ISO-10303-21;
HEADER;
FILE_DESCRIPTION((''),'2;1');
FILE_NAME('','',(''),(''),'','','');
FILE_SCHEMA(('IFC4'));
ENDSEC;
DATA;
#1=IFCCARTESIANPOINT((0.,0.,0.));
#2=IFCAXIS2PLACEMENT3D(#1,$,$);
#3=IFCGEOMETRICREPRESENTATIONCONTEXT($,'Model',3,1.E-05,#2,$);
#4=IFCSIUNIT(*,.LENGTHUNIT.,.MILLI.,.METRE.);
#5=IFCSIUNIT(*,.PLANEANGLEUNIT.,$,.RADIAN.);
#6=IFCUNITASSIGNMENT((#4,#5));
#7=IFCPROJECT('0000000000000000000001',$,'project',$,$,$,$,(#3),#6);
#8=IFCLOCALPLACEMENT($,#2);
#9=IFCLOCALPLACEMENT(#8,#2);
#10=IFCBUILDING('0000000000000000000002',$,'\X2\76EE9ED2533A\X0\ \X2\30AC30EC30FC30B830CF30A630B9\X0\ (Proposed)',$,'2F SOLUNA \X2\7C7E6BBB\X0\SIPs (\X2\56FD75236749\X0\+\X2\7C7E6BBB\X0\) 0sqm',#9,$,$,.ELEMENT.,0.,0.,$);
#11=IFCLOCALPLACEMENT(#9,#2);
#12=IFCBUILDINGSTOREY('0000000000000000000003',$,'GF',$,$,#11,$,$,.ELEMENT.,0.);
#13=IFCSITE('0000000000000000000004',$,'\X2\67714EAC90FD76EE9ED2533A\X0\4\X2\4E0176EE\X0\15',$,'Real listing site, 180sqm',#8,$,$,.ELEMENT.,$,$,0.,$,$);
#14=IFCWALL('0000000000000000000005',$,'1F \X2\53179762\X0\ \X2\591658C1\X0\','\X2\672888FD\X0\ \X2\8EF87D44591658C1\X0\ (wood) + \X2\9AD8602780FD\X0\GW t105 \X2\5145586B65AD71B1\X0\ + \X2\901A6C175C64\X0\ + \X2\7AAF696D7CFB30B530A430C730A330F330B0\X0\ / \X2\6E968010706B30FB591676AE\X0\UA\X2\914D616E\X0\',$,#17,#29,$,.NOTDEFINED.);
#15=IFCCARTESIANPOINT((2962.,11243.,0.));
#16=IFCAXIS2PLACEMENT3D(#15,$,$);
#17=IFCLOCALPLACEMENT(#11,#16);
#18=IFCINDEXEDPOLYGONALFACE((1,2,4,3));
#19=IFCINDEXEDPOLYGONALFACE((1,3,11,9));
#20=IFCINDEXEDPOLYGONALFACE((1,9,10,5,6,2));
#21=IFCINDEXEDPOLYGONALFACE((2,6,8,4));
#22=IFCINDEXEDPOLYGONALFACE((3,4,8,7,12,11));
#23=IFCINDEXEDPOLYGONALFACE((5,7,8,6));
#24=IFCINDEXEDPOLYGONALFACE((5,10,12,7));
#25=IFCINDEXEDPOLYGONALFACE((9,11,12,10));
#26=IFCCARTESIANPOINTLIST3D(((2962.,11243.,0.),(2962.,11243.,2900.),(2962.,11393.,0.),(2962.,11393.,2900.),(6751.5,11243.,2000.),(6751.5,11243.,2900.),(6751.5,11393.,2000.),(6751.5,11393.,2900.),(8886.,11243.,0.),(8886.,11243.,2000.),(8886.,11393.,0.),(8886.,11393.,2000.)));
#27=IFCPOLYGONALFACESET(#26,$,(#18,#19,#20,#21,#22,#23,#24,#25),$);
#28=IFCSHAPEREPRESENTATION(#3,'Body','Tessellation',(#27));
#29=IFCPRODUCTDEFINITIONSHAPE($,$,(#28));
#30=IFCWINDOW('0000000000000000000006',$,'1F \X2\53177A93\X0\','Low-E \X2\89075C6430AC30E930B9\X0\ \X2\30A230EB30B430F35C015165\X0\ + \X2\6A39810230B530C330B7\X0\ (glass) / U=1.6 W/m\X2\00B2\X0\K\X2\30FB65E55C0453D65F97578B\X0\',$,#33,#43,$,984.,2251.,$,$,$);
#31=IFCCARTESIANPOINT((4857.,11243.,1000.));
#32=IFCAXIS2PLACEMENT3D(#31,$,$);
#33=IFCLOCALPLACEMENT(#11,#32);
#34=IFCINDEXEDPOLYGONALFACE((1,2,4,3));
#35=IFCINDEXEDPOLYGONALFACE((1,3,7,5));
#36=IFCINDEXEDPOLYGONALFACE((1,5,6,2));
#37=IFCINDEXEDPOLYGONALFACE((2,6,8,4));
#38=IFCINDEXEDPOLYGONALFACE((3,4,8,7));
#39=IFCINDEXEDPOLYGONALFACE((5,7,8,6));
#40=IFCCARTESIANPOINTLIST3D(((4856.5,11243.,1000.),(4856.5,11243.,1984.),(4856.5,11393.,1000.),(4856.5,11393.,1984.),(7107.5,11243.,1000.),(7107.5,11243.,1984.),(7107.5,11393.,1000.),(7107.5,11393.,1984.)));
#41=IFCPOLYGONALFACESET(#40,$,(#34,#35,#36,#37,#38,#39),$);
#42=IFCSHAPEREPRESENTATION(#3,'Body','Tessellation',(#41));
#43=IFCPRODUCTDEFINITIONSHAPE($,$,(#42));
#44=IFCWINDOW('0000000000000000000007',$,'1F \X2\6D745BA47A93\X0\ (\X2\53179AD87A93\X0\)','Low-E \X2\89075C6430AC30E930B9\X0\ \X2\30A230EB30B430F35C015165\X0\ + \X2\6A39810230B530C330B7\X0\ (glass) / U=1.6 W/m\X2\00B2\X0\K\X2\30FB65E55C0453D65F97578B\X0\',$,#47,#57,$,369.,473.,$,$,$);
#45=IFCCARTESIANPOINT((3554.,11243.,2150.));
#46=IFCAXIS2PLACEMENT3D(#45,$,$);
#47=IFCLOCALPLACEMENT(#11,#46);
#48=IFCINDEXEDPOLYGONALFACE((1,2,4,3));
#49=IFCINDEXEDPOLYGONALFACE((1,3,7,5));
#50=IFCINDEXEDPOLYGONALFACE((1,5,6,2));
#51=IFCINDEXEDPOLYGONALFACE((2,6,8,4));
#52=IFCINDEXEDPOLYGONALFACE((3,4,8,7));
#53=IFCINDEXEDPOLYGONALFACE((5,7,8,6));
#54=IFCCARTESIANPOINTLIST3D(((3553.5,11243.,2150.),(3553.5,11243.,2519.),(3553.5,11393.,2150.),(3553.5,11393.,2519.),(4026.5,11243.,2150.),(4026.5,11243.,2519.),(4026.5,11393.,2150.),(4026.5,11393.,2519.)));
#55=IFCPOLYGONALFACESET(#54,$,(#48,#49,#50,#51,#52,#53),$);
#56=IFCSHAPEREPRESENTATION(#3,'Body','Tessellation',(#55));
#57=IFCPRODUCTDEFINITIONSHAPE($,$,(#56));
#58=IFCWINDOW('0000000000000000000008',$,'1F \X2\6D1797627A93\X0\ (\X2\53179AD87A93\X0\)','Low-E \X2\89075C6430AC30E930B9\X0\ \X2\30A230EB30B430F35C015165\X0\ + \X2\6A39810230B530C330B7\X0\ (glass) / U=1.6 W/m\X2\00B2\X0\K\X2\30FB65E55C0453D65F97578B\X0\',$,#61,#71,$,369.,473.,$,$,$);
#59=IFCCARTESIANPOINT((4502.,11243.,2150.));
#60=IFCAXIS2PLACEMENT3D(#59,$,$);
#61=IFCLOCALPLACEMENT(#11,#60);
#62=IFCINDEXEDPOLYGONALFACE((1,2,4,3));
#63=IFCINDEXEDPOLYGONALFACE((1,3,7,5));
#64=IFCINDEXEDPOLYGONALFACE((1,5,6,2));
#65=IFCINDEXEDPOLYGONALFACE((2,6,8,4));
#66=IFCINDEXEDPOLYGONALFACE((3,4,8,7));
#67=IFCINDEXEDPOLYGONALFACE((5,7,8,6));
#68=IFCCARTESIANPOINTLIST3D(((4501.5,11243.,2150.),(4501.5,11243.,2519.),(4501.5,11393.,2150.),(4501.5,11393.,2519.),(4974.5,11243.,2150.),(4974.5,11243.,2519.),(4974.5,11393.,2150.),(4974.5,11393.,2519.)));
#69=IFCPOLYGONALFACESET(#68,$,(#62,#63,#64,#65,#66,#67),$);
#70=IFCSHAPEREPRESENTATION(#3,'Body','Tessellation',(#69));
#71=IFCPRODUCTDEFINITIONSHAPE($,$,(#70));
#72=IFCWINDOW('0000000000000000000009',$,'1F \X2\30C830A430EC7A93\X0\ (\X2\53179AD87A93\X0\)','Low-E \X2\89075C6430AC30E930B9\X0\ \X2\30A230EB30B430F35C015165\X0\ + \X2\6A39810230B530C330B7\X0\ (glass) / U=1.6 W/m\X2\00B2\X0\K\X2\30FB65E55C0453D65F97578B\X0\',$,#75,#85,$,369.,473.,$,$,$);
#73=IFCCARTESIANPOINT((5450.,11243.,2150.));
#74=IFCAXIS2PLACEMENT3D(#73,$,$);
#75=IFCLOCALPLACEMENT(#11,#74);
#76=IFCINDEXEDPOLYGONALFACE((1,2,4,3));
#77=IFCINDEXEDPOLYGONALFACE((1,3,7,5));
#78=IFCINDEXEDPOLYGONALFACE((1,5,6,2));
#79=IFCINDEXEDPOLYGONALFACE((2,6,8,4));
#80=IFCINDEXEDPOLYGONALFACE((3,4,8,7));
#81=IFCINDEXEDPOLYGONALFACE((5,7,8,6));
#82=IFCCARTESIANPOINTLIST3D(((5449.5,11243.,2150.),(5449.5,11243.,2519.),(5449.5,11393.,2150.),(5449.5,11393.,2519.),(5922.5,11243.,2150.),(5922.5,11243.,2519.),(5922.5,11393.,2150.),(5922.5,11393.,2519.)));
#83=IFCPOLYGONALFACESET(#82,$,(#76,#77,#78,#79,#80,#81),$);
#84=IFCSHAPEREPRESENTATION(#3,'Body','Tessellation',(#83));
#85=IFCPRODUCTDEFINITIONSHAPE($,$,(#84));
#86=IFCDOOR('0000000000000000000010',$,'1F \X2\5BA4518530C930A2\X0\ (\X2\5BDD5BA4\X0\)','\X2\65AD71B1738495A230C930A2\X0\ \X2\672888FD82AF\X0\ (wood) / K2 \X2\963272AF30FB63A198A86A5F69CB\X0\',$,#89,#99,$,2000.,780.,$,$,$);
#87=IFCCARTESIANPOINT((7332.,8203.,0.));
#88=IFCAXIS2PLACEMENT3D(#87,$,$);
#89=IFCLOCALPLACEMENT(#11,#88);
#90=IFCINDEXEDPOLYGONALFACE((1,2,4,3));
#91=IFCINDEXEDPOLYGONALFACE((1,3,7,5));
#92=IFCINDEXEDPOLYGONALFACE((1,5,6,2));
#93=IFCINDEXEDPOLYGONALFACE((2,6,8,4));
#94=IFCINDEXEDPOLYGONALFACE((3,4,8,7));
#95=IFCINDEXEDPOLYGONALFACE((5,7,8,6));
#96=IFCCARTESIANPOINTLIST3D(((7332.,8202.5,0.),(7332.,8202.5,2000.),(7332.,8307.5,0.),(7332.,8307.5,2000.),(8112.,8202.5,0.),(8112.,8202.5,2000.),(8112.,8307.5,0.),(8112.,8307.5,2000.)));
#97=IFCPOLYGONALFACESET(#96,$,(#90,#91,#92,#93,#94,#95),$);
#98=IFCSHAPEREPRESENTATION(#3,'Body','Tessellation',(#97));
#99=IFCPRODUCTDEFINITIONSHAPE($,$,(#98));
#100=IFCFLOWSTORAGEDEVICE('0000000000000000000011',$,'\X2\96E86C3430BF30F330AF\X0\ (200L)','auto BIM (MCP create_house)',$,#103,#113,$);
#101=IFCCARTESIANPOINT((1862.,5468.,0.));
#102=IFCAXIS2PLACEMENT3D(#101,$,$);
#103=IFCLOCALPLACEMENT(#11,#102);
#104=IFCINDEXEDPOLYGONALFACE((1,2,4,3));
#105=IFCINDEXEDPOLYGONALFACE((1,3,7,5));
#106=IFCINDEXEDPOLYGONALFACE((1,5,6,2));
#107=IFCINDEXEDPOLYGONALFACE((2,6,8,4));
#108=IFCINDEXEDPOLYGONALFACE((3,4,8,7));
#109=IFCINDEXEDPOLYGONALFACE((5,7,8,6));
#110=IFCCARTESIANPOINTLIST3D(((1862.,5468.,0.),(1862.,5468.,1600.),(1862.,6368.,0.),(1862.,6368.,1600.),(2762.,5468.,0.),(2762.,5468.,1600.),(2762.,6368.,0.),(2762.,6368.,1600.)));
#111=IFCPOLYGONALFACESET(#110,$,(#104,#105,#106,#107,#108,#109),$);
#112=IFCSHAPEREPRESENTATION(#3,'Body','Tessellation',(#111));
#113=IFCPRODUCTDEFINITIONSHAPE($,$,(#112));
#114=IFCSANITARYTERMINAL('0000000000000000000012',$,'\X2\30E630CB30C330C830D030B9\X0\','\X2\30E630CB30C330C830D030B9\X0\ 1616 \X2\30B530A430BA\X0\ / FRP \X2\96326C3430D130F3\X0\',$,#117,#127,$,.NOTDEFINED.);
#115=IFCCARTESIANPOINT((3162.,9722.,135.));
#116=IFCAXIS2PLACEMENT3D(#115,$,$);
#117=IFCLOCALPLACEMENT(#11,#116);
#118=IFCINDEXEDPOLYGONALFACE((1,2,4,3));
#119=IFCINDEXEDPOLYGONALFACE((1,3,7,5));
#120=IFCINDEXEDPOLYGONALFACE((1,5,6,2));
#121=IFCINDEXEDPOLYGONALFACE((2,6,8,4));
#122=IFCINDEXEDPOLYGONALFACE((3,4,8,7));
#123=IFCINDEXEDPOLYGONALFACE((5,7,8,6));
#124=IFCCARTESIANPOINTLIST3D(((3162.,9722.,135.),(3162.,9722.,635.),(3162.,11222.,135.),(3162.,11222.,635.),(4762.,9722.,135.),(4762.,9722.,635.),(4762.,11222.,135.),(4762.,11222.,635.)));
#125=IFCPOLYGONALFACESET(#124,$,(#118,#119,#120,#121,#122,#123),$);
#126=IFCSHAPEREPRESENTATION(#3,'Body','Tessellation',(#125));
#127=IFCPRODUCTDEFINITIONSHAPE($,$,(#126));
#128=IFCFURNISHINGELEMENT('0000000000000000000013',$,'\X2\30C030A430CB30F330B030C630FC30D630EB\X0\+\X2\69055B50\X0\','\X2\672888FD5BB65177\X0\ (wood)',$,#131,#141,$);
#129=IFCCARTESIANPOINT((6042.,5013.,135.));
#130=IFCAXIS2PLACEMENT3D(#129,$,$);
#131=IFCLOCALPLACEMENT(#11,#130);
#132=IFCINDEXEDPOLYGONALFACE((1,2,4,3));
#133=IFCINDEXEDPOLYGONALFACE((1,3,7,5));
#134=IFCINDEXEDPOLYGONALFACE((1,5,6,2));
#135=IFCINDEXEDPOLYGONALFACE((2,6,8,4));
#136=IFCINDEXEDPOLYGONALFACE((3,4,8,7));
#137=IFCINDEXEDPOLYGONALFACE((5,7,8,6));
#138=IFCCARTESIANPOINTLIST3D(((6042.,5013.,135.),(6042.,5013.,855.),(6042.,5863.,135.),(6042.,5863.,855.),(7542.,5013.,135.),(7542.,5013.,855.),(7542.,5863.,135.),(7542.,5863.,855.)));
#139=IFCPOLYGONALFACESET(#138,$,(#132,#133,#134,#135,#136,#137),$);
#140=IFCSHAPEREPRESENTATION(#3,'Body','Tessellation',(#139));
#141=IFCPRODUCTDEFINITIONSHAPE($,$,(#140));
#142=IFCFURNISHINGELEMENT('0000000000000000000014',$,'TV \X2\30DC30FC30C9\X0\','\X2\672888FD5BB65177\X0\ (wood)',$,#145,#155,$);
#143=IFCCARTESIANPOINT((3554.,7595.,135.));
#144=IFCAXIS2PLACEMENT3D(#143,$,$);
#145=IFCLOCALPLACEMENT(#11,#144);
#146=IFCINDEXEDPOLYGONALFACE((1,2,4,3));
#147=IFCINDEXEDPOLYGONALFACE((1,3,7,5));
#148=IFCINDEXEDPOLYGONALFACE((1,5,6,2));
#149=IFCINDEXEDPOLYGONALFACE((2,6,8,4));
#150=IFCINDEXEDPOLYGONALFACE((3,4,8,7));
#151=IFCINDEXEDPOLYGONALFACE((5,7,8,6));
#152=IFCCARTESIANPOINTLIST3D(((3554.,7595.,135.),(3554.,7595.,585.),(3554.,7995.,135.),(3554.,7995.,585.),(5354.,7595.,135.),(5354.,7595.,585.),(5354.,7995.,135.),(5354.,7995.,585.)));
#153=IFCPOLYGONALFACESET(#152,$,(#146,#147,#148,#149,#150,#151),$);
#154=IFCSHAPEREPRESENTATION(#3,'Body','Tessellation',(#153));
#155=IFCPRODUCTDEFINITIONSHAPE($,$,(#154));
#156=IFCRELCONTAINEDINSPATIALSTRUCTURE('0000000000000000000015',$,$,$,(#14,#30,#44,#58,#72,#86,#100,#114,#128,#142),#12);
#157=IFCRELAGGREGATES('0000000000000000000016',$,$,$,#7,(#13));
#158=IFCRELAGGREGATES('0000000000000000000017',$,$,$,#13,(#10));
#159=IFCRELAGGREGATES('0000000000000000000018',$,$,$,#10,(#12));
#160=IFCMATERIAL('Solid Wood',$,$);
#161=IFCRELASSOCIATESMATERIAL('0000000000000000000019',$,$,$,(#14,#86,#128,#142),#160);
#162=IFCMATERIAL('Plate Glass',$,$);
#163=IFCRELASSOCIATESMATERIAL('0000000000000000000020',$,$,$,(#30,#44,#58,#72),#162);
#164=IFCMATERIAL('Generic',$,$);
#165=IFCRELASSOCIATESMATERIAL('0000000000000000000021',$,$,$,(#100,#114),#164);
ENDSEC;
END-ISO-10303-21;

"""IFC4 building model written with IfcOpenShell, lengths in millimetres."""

from ifc_helpers import new_model, si_unit, frame, frame_2d, origin, place, context, project, spatial, rectangle, extrude, material, element, fill, save


model = new_model("IFC4")

# Units and contexts
model_context = context("Model", 3, precision=1e-05, world=origin())
ifc_project = project(units=[si_unit("LENGTHUNIT", "METRE", prefix="MILLI"), si_unit("PLANEANGLEUNIT", "RADIAN")], contexts=[model_context])

# Site, building, storey
site_placement = place(None, origin())
site = spatial("IfcSite", under=ifc_project, at=site_placement, Name="東京都目黒区4丁目15", ObjectType="Real listing site, 180sqm", CompositionType="ELEMENT", RefElevation=0.0)
building_placement = place(site_placement, origin())
building = spatial("IfcBuilding", under=site, at=building_placement, Name="目黒区 ガレージハウス (Proposed)", ObjectType="2F SOLUNA 籾殻SIPs (国産杉+籾殻) 0sqm", CompositionType="ELEMENT", ElevationOfRefHeight=0.0, ElevationOfTerrain=0.0)
storey_placement = place(building_placement, origin())
storey = spatial("IfcBuildingStorey", under=building, at=storey_placement, Name="GF", CompositionType="ELEMENT", Elevation=0.0)

# Wall, openings, windows
ifc_material_1 = material(Name="Solid Wood")
wall_1_placement = place(storey_placement, frame((2962.0, 11243.0, 0.0)))
wall_1 = element("IfcWall", 1, at=wall_1_placement, inside=storey, material=ifc_material_1, Name="1F 北面 外壁", Description="木製 軸組外壁 (wood) + 高性能GW t105 充填断熱 + 通気層 + 窯業系サイディング / 準耐火・外皮UA配慮", PredefinedType="NOTDEFINED", context=model_context, shape_type="SweptSolid", body=[
    extrude(rectangle(XDim=5924.0, YDim=150.0, at=frame_2d((2962.0, 75.0))), frame((2962.0, 11243.0, 0.0)), (0.0, 0.0, 1.0), 2900.0),
])
opening_1_placement = place(storey_placement, frame((4857.0, 11243.0, 1000.0)))
opening_1 = element("IfcOpeningElement", 2, at=opening_1_placement, cuts=wall_1, PredefinedType="NOTDEFINED", context=model_context, shape_type="SweptSolid", body=[
    extrude(rectangle(XDim=2251.0, YDim=150.0, at=frame_2d((1125.0, 75.0))), frame((4857.0, 11243.0, 1000.0)), (0.0, 0.0, 1.0), 984.0),
])
opening_2_placement = place(storey_placement, frame((3554.0, 11243.0, 2150.0)))
opening_2 = element("IfcOpeningElement", 3, at=opening_2_placement, cuts=wall_1, PredefinedType="NOTDEFINED", context=model_context, shape_type="SweptSolid", body=[
    extrude(rectangle(XDim=473.0, YDim=150.0, at=frame_2d((236.0, 75.0))), frame((3554.0, 11243.0, 2150.0)), (0.0, 0.0, 1.0), 369.0),
])
opening_3_placement = place(storey_placement, frame((4502.0, 11243.0, 2150.0)))
opening_3 = element("IfcOpeningElement", 4, at=opening_3_placement, cuts=wall_1, PredefinedType="NOTDEFINED", context=model_context, shape_type="SweptSolid", body=[
    extrude(rectangle(XDim=473.0, YDim=150.0, at=frame_2d((236.0, 75.0))), frame((4502.0, 11243.0, 2150.0)), (0.0, 0.0, 1.0), 369.0),
])
opening_4_placement = place(storey_placement, frame((5450.0, 11243.0, 2150.0)))
opening_4 = element("IfcOpeningElement", 5, at=opening_4_placement, cuts=wall_1, PredefinedType="NOTDEFINED", context=model_context, shape_type="SweptSolid", body=[
    extrude(rectangle(XDim=473.0, YDim=150.0, at=frame_2d((236.0, 75.0))), frame((5450.0, 11243.0, 2150.0)), (0.0, 0.0, 1.0), 369.0),
])
ifc_material_2 = material(Name="Plate Glass")
window_1_placement = place(storey_placement, frame((4857.0, 11243.0, 1000.0)))
window_1 = element("IfcWindow", 6, at=window_1_placement, inside=storey, material=ifc_material_2, Name="1F 北窓", Description="Low-E 複層ガラス アルゴン封入 + 樹脂サッシ (glass) / U=1.6 W/m²K・日射取得型", OverallHeight=984.0, OverallWidth=2251.0, context=model_context, shape_type="SweptSolid", body=[
    extrude(rectangle(XDim=2251.0, YDim=150.0, at=frame_2d((1125.0, 75.0))), frame((4857.0, 11243.0, 1000.0)), (0.0, 0.0, 1.0), 984.0),
])
fill(opening_1, window_1)
window_2_placement = place(storey_placement, frame((3554.0, 11243.0, 2150.0)))
window_2 = element("IfcWindow", 7, at=window_2_placement, inside=storey, material=ifc_material_2, Name="1F 浴室窓 (北高窓)", Description="Low-E 複層ガラス アルゴン封入 + 樹脂サッシ (glass) / U=1.6 W/m²K・日射取得型", OverallHeight=369.0, OverallWidth=473.0, context=model_context, shape_type="SweptSolid", body=[
    extrude(rectangle(XDim=473.0, YDim=150.0, at=frame_2d((236.0, 75.0))), frame((3554.0, 11243.0, 2150.0)), (0.0, 0.0, 1.0), 369.0),
])
fill(opening_2, window_2)
window_3_placement = place(storey_placement, frame((4502.0, 11243.0, 2150.0)))
window_3 = element("IfcWindow", 8, at=window_3_placement, inside=storey, material=ifc_material_2, Name="1F 洗面窓 (北高窓)", Description="Low-E 複層ガラス アルゴン封入 + 樹脂サッシ (glass) / U=1.6 W/m²K・日射取得型", OverallHeight=369.0, OverallWidth=473.0, context=model_context, shape_type="SweptSolid", body=[
    extrude(rectangle(XDim=473.0, YDim=150.0, at=frame_2d((236.0, 75.0))), frame((4502.0, 11243.0, 2150.0)), (0.0, 0.0, 1.0), 369.0),
])
fill(opening_3, window_3)
window_4_placement = place(storey_placement, frame((5450.0, 11243.0, 2150.0)))
window_4 = element("IfcWindow", 9, at=window_4_placement, inside=storey, material=ifc_material_2, Name="1F トイレ窓 (北高窓)", Description="Low-E 複層ガラス アルゴン封入 + 樹脂サッシ (glass) / U=1.6 W/m²K・日射取得型", OverallHeight=369.0, OverallWidth=473.0, context=model_context, shape_type="SweptSolid", body=[
    extrude(rectangle(XDim=473.0, YDim=150.0, at=frame_2d((236.0, 75.0))), frame((5450.0, 11243.0, 2150.0)), (0.0, 0.0, 1.0), 369.0),
])
fill(opening_4, window_4)

# Door
door_1_placement = place(storey_placement, frame((7332.0, 8203.0, 0.0)))
element("IfcDoor", 10, at=door_1_placement, inside=storey, material=ifc_material_1, Name="1F 室内ドア (寝室)", Description="断熱玄関ドア 木製芯 (wood) / K2 防犯・採風機構", OverallHeight=2000.0, OverallWidth=780.0, context=model_context, shape_type="SweptSolid", body=[
    extrude(rectangle(XDim=780.0, YDim=105.0, at=frame_2d((390.0, 52.0))), frame((7332.0, 8203.0, 0.0)), (0.0, 0.0, 1.0), 2000.0),
])

# Flow storage device
ifc_material_3 = material(Name="Generic")
flow_storage_device_placement = place(storey_placement, frame((1862.0, 5468.0, 0.0)))
element("IfcFlowStorageDevice", 11, at=flow_storage_device_placement, inside=storey, material=ifc_material_3, Name="雨水タンク (200L)", Description="auto BIM (MCP create_house)", context=model_context, shape_type="SweptSolid", body=[
    extrude(rectangle(XDim=900.0, YDim=900.0, at=frame_2d((450.0, 450.0))), frame((1862.0, 5468.0, 0.0)), (0.0, 0.0, 1.0), 1600.0),
])

# Sanitary terminal
sanitary_terminal_placement = place(storey_placement, frame((3162.0, 9722.0, 135.0)))
element("IfcSanitaryTerminal", 12, at=sanitary_terminal_placement, inside=storey, material=ifc_material_3, Name="ユニットバス", Description="ユニットバス 1616 サイズ / FRP 防水パン", PredefinedType="NOTDEFINED", context=model_context, shape_type="SweptSolid", body=[
    extrude(rectangle(XDim=1600.0, YDim=1500.0, at=frame_2d((800.0, 750.0))), frame((3162.0, 9722.0, 135.0)), (0.0, 0.0, 1.0), 500.0),
])

# Furnishing elements
furnishing_1_placement = place(storey_placement, frame((6042.0, 5013.0, 135.0)))
element("IfcFurnishingElement", 13, at=furnishing_1_placement, inside=storey, material=ifc_material_1, Name="ダイニングテーブル+椅子", Description="木製家具 (wood)", context=model_context, shape_type="SweptSolid", body=[
    extrude(rectangle(XDim=1500.0, YDim=850.0, at=frame_2d((750.0, 425.0))), frame((6042.0, 5013.0, 135.0)), (0.0, 0.0, 1.0), 720.0),
])
furnishing_2_placement = place(storey_placement, frame((3554.0, 7595.0, 135.0)))
element("IfcFurnishingElement", 14, at=furnishing_2_placement, inside=storey, material=ifc_material_1, Name="TV ボード", Description="木製家具 (wood)", context=model_context, shape_type="SweptSolid", body=[
    extrude(rectangle(XDim=1800.0, YDim=400.0, at=frame_2d((900.0, 200.0))), frame((3554.0, 7595.0, 135.0)), (0.0, 0.0, 1.0), 450.0),
])

save(model, "model.ifc")
